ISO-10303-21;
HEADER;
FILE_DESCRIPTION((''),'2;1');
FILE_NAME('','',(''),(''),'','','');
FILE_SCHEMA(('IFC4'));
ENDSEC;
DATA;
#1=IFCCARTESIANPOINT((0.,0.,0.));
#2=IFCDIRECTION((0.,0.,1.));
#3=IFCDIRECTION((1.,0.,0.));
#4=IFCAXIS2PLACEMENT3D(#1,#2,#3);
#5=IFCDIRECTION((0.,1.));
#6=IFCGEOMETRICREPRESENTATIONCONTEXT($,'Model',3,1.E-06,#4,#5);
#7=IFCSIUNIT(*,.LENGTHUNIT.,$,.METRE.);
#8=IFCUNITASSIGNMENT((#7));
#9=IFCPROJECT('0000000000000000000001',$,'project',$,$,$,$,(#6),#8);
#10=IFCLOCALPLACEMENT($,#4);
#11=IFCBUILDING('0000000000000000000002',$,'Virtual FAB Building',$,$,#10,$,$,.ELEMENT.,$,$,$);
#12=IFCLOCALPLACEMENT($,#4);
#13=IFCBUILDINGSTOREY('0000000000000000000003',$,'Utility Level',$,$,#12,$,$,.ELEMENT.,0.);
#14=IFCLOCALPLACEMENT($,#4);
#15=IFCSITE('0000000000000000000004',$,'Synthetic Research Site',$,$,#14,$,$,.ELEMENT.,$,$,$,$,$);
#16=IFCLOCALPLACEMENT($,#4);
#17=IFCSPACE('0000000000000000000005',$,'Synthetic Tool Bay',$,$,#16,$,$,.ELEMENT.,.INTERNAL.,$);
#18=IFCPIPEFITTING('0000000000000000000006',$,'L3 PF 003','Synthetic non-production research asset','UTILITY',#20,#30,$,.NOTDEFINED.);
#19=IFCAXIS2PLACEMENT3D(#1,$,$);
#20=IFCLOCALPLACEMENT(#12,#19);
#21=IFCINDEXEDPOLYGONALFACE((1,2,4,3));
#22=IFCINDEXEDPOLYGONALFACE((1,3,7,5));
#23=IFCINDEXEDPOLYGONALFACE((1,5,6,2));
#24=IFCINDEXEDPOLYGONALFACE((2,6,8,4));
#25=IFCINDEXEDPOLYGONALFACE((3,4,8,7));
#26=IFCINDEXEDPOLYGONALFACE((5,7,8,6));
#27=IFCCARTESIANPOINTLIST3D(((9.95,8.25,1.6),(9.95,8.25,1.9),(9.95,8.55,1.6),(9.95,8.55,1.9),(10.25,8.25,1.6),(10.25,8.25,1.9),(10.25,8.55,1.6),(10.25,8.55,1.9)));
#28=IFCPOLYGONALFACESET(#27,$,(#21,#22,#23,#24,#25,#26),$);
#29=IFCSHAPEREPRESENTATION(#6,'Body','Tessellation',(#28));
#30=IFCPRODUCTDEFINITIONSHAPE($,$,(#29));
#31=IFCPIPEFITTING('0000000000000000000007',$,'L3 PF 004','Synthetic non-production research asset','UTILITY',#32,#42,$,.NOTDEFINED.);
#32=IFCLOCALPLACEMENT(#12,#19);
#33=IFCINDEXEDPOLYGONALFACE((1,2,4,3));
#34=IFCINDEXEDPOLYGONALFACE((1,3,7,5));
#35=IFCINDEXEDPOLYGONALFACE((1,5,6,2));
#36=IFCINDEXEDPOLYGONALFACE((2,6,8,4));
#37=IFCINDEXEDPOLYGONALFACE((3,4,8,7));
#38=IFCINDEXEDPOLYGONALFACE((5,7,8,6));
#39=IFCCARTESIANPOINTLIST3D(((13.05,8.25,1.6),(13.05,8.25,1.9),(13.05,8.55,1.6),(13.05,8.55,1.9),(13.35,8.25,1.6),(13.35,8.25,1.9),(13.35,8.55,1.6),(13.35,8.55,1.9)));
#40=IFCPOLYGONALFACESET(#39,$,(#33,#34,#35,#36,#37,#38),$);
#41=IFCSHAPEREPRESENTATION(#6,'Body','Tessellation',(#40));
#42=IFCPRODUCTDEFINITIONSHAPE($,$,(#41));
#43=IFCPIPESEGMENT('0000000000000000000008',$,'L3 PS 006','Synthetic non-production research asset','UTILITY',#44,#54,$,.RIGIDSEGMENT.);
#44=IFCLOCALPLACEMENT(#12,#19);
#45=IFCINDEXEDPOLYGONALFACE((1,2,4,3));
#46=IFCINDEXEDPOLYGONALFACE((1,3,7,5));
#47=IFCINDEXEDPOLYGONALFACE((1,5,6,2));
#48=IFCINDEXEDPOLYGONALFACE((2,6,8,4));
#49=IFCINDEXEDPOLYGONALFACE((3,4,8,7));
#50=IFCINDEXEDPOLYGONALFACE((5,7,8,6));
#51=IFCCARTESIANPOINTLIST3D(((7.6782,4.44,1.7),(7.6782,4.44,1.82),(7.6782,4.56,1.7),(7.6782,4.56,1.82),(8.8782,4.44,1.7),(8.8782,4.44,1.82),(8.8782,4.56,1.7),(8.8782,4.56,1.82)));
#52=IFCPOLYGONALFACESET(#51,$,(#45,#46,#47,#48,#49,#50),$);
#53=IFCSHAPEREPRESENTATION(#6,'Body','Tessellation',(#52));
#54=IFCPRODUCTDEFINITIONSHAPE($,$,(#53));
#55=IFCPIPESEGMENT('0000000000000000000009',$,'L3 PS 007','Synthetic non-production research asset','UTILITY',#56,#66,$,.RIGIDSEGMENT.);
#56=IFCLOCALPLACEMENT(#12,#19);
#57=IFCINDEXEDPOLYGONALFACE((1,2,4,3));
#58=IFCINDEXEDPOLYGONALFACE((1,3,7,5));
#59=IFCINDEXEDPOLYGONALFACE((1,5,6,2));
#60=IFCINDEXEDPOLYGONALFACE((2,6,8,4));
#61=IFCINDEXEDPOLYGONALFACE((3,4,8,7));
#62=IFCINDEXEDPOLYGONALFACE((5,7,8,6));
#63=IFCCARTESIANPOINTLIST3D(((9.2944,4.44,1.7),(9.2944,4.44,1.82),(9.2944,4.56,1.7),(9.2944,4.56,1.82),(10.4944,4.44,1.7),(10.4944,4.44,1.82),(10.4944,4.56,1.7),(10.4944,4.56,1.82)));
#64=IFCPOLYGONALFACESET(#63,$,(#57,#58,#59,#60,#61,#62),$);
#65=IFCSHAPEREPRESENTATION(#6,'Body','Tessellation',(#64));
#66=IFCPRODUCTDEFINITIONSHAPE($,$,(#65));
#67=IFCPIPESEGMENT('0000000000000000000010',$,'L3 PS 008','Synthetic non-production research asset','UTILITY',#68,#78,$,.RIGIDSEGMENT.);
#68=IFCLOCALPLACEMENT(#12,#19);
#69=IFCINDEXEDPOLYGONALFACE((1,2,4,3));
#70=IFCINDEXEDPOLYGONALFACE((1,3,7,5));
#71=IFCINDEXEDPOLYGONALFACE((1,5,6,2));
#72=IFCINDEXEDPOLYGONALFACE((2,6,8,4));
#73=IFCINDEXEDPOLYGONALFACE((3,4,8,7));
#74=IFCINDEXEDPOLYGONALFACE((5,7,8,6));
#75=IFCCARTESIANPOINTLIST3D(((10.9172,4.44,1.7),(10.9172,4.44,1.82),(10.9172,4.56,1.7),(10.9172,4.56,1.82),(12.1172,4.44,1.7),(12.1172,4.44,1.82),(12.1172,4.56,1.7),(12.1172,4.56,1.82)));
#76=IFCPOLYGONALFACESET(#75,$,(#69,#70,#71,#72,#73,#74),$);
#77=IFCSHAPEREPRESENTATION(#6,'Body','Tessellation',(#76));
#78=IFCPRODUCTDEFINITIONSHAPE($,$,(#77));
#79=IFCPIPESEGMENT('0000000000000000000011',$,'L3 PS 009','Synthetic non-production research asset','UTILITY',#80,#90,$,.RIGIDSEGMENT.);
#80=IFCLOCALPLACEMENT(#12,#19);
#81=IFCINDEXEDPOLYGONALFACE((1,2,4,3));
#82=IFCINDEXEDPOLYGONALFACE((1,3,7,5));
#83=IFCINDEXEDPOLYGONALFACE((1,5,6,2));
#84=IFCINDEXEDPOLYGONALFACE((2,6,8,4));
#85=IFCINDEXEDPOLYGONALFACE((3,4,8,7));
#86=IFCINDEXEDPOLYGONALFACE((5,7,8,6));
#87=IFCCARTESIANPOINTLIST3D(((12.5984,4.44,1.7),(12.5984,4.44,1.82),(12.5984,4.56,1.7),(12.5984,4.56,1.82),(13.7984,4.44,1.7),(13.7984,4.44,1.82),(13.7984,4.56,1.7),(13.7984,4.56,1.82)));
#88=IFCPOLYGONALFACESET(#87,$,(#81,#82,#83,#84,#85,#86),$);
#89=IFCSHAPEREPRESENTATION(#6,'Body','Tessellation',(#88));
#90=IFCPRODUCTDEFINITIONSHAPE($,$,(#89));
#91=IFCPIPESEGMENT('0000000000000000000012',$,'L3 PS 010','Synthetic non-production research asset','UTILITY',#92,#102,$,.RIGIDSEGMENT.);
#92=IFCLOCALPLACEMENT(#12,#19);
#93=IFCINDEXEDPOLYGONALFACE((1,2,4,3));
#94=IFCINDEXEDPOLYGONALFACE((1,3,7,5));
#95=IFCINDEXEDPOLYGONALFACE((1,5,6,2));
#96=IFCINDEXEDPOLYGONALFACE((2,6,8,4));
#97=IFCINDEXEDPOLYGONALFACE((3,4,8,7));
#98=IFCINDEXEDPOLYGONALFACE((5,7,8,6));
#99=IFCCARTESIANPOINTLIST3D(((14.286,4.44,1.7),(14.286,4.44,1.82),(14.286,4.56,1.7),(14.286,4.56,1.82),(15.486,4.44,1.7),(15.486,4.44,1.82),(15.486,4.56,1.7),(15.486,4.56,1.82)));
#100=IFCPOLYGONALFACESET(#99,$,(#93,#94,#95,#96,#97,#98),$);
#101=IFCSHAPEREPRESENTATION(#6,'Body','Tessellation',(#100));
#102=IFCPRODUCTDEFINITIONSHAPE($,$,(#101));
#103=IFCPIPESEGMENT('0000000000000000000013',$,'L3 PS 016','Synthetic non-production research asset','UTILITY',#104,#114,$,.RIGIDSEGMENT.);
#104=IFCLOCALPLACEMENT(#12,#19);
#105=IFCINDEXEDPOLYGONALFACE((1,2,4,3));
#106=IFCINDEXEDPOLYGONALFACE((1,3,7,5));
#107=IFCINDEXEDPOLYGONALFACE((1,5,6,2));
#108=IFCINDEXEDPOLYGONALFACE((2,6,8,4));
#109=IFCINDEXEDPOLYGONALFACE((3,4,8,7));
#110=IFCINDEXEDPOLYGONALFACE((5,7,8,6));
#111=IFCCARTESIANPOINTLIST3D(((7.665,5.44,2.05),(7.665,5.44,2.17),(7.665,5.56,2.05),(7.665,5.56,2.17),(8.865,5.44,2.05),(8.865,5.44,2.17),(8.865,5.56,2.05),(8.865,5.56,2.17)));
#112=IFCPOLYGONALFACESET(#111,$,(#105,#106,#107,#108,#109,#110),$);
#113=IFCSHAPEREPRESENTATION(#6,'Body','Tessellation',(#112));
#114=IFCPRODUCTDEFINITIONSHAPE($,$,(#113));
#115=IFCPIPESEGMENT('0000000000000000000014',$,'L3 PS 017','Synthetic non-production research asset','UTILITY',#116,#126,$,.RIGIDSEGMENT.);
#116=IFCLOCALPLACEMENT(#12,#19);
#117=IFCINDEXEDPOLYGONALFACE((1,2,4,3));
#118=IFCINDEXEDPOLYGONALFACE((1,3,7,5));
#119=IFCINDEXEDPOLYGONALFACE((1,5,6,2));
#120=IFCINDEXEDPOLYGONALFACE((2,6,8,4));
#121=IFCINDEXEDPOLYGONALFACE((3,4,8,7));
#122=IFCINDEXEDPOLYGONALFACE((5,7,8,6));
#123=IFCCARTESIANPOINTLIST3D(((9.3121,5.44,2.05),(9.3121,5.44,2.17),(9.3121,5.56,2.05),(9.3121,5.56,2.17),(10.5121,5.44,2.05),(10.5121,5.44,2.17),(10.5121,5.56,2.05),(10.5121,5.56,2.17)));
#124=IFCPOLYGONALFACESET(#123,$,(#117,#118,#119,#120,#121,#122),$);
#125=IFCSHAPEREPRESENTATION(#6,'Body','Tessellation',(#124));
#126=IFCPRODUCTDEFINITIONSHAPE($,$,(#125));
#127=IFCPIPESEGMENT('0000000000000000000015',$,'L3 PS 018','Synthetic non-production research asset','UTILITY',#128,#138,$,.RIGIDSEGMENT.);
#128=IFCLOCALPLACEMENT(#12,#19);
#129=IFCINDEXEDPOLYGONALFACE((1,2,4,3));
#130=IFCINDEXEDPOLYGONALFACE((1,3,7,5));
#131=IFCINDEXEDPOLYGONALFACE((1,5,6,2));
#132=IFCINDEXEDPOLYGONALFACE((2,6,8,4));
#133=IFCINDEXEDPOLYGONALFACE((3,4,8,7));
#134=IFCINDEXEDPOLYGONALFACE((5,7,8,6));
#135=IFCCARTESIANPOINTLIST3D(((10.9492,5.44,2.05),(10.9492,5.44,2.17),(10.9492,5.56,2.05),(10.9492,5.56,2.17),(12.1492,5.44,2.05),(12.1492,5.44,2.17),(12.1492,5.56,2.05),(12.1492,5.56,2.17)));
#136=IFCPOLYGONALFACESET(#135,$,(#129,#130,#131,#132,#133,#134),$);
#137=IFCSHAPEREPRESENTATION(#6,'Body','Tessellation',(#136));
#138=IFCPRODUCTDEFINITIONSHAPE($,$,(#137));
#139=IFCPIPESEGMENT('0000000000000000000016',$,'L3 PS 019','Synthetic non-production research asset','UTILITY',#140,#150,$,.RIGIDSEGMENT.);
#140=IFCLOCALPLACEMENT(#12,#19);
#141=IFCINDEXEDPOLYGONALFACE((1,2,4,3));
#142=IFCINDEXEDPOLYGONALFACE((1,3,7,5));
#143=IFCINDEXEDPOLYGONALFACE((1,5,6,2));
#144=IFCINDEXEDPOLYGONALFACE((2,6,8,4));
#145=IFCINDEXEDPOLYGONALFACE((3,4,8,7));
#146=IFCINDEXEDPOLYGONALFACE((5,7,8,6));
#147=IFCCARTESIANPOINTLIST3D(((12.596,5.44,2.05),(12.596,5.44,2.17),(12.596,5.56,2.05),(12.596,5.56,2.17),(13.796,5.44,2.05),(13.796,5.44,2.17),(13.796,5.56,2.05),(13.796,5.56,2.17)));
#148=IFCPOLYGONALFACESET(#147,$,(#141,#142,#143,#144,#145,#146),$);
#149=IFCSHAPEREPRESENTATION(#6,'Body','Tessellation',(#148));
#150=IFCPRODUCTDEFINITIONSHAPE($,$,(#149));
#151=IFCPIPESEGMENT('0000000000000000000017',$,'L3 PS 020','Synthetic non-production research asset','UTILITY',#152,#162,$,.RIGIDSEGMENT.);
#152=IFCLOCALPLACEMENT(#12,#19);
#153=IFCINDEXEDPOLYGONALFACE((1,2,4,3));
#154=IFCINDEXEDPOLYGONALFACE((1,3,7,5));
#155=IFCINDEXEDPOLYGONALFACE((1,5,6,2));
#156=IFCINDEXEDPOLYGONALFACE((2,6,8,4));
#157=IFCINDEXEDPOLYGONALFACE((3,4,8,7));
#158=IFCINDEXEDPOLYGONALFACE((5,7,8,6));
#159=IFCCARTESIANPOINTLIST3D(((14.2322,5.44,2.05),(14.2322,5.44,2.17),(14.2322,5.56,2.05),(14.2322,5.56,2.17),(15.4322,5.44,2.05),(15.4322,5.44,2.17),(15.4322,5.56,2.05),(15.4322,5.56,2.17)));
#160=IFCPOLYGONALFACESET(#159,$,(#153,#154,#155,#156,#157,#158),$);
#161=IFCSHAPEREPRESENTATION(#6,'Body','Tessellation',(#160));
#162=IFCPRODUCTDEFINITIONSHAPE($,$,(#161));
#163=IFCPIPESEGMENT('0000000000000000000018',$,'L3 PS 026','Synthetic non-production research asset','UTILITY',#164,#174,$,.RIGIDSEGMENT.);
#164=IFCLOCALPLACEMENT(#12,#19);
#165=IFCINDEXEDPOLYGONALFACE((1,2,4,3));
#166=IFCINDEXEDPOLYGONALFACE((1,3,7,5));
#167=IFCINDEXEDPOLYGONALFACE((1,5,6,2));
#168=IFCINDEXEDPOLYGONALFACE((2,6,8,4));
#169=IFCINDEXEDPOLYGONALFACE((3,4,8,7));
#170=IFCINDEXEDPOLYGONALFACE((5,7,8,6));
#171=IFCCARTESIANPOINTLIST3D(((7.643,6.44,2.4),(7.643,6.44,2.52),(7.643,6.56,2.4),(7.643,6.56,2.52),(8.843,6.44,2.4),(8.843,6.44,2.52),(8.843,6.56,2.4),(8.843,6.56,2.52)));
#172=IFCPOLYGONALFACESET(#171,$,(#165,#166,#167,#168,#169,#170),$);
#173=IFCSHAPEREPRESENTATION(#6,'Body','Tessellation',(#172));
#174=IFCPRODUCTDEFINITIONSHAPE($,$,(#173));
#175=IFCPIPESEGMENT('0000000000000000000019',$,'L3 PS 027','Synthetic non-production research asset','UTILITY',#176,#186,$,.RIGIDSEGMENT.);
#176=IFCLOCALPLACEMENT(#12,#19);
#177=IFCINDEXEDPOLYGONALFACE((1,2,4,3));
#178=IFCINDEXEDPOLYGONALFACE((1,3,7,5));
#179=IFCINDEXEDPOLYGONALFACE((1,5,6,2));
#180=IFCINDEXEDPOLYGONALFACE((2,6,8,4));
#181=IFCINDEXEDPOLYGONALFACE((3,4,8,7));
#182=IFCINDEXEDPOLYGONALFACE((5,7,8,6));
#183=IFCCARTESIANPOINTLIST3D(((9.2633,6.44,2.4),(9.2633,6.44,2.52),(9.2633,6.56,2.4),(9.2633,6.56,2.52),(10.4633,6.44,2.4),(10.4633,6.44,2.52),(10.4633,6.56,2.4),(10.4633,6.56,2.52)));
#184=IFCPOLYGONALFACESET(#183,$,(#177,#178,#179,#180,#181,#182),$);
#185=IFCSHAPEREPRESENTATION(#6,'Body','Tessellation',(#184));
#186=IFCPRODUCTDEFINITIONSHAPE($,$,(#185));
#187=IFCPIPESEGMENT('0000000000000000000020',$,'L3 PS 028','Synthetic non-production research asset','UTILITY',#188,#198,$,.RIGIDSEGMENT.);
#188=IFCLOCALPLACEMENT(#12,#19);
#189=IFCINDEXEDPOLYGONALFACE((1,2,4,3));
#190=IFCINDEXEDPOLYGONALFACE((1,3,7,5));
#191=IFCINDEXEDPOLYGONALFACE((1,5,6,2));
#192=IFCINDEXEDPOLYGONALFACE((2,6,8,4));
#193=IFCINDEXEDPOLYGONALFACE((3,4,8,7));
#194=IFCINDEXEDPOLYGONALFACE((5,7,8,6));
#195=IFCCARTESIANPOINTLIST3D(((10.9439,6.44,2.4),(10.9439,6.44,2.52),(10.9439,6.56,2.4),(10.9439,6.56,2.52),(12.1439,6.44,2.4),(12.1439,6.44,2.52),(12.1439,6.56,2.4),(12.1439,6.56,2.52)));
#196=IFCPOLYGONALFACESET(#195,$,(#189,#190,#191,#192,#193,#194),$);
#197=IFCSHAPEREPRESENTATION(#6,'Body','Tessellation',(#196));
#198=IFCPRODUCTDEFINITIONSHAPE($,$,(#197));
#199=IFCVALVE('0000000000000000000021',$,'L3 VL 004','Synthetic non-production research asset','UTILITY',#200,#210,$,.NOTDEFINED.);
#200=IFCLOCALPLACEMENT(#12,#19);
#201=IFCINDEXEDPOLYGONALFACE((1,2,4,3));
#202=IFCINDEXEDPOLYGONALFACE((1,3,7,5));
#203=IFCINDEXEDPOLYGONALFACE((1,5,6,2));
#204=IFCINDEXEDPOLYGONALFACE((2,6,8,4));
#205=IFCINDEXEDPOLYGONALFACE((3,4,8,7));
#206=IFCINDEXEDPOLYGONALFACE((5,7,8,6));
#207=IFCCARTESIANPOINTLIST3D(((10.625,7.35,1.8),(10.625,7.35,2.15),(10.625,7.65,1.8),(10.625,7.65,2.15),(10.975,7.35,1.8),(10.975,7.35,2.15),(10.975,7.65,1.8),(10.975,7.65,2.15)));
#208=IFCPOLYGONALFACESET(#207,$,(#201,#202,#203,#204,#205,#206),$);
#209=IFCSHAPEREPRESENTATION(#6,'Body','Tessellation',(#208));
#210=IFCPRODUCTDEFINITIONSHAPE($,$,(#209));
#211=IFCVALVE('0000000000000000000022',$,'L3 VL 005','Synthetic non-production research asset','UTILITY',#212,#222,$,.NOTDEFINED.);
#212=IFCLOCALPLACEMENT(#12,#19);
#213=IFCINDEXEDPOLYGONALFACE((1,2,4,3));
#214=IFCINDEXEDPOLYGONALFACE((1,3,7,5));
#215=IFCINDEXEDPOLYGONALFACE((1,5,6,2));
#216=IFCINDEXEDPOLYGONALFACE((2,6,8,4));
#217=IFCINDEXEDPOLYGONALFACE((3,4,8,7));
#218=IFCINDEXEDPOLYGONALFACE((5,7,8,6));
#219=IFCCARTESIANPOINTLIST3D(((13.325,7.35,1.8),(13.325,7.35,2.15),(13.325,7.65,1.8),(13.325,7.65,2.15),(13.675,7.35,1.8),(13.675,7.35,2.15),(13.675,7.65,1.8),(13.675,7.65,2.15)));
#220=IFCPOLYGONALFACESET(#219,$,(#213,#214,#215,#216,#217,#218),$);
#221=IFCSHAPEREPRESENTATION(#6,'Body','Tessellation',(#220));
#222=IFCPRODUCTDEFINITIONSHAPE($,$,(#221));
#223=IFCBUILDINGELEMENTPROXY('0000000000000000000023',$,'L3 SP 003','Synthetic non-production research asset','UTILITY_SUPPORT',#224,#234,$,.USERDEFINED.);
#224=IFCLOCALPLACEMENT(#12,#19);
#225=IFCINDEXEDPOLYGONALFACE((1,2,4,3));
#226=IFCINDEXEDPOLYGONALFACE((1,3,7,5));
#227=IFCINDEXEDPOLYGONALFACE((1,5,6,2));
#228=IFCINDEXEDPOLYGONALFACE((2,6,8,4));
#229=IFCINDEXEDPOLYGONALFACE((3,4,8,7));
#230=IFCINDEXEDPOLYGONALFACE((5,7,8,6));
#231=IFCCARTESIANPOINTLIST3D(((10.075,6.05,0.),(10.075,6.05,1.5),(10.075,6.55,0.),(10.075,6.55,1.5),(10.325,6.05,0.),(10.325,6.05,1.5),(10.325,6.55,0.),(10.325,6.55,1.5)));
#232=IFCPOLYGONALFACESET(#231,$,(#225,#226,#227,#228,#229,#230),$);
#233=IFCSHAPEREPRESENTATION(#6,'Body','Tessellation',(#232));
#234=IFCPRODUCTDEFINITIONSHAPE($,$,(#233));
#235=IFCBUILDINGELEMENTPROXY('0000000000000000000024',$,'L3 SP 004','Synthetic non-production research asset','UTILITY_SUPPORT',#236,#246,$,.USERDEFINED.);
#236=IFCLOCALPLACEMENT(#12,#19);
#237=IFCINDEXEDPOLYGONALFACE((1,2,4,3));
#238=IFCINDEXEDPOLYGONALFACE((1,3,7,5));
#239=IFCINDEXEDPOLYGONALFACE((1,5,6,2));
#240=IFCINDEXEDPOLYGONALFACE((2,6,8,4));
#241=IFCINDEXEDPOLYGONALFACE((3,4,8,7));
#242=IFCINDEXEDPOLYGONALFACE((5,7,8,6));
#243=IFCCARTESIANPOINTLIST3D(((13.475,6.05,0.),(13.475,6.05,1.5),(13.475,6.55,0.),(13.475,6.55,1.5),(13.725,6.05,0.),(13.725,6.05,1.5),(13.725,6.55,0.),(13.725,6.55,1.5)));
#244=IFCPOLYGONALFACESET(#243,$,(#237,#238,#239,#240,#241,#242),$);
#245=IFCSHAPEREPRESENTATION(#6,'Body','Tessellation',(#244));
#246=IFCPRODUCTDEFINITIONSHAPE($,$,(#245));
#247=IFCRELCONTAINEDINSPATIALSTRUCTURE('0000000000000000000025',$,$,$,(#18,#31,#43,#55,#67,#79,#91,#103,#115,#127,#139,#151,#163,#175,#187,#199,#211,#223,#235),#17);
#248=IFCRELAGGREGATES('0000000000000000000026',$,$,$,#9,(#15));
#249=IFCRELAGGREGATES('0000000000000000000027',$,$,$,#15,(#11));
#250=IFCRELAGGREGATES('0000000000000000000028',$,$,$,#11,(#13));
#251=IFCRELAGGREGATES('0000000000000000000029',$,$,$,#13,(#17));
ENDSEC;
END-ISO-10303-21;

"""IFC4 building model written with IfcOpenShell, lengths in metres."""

from ifc_helpers import new_model, si_unit, direction, frame, origin_with_axes, origin_2d_with_axis, place, context, project, spatial, rectangle, extrude, element, save


model = new_model("IFC4")

# Units and contexts
model_context = context("Model", 3, precision=1e-06, world=origin_with_axes(), true_north=direction((0.0, 1.0)))
ifc_project = project(units=[si_unit("LENGTHUNIT", "METRE")], contexts=[model_context])

# Site, building, storey, space
site_placement = place(None, origin_with_axes())
site = spatial("IfcSite", under=ifc_project, at=site_placement, Name="Synthetic Research Site", CompositionType="ELEMENT")
building_placement = place(None, origin_with_axes())
building = spatial("IfcBuilding", under=site, at=building_placement, Name="Virtual FAB Building", CompositionType="ELEMENT")
storey_placement = place(None, origin_with_axes())
storey = spatial("IfcBuildingStorey", under=building, at=storey_placement, Name="Utility Level", CompositionType="ELEMENT", Elevation=0.0)
space_placement = place(None, origin_with_axes())
space = spatial("IfcSpace", under=storey, at=space_placement, Name="Synthetic Tool Bay", CompositionType="ELEMENT", PredefinedType="INTERNAL")

# Pipe fittings
for number, where, z_axis, x_axis, name in (
    (1, (10.1, 8.4, 1.6), (0.0, 0.0, 1.0), (1.0, 0.0, 0.0), "L3 PF 003"),
    (2, (13.2, 8.4, 1.6), (0.0, 0.0, 1.0), (1.0, 0.0, 0.0), "L3 PF 004"),
):
    element("IfcPipeFitting", number, at=place(None, frame(where, z_axis=z_axis, x_axis=x_axis)), inside=space, Name=name, Description="Synthetic non-production research asset", ObjectType="UTILITY", PredefinedType="NOTDEFINED", context=model_context, shape_type="SweptSolid", body=[
        extrude(rectangle(XDim=0.3, YDim=0.3, at=origin_2d_with_axis()), origin_with_axes(), (0.0, 0.0, 1.0), 0.3),
    ])

# Pipe segments
for number, where, z_axis, x_axis, name in (
    (3, (8.2782, 4.5, 1.7), (0.0, 0.0, 1.0), (1.0, 0.0, 0.0), "L3 PS 006"),
    (4, (9.8944, 4.5, 1.7), (0.0, 0.0, 1.0), (1.0, 0.0, 0.0), "L3 PS 007"),
    (5, (11.5172, 4.5, 1.7), (0.0, 0.0, 1.0), (1.0, 0.0, 0.0), "L3 PS 008"),
    (6, (13.1984, 4.5, 1.7), (0.0, 0.0, 1.0), (1.0, 0.0, 0.0), "L3 PS 009"),
    (7, (14.886, 4.5, 1.7), (0.0, 0.0, 1.0), (1.0, 0.0, 0.0), "L3 PS 010"),
    (8, (8.265, 5.5, 2.05), (0.0, 0.0, 1.0), (1.0, 0.0, 0.0), "L3 PS 016"),
    (9, (9.9121, 5.5, 2.05), (0.0, 0.0, 1.0), (1.0, 0.0, 0.0), "L3 PS 017"),
    (10, (11.5492, 5.5, 2.05), (0.0, 0.0, 1.0), (1.0, 0.0, 0.0), "L3 PS 018"),
    (11, (13.196, 5.5, 2.05), (0.0, 0.0, 1.0), (1.0, 0.0, 0.0), "L3 PS 019"),
    (12, (14.8322, 5.5, 2.05), (0.0, 0.0, 1.0), (1.0, 0.0, 0.0), "L3 PS 020"),
    (13, (8.243, 6.5, 2.4), (0.0, 0.0, 1.0), (1.0, 0.0, 0.0), "L3 PS 026"),
    (14, (9.8633, 6.5, 2.4), (0.0, 0.0, 1.0), (1.0, 0.0, 0.0), "L3 PS 027"),
    (15, (11.5439, 6.5, 2.4), (0.0, 0.0, 1.0), (1.0, 0.0, 0.0), "L3 PS 028"),
):
    element("IfcPipeSegment", number, at=place(None, frame(where, z_axis=z_axis, x_axis=x_axis)), inside=space, Name=name, Description="Synthetic non-production research asset", ObjectType="UTILITY", PredefinedType="RIGIDSEGMENT", context=model_context, shape_type="SweptSolid", body=[
        extrude(rectangle(XDim=1.2, YDim=0.12, at=origin_2d_with_axis()), origin_with_axes(), (0.0, 0.0, 1.0), 0.12),
    ])

# Valves
for number, where, z_axis, x_axis, name in (
    (16, (10.8, 7.5, 1.8), (0.0, 0.0, 1.0), (1.0, 0.0, 0.0), "L3 VL 004"),
    (17, (13.5, 7.5, 1.8), (0.0, 0.0, 1.0), (1.0, 0.0, 0.0), "L3 VL 005"),
):
    element("IfcValve", number, at=place(None, frame(where, z_axis=z_axis, x_axis=x_axis)), inside=space, Name=name, Description="Synthetic non-production research asset", ObjectType="UTILITY", PredefinedType="NOTDEFINED", context=model_context, shape_type="SweptSolid", body=[
        extrude(rectangle(XDim=0.35, YDim=0.3, at=origin_2d_with_axis()), origin_with_axes(), (0.0, 0.0, 1.0), 0.35),
    ])

# Building element proxies
for number, where, z_axis, x_axis, name in (
    (18, (10.2, 6.3, 0.0), (0.0, 0.0, 1.0), (1.0, 0.0, 0.0), "L3 SP 003"),
    (19, (13.6, 6.3, 0.0), (0.0, 0.0, 1.0), (1.0, 0.0, 0.0), "L3 SP 004"),
):
    element("IfcBuildingElementProxy", number, at=place(None, frame(where, z_axis=z_axis, x_axis=x_axis)), inside=space, Name=name, Description="Synthetic non-production research asset", ObjectType="UTILITY_SUPPORT", PredefinedType="USERDEFINED", context=model_context, shape_type="SweptSolid", body=[
        extrude(rectangle(XDim=0.25, YDim=0.5, at=origin_2d_with_axis()), origin_with_axes(), (0.0, 0.0, 1.0), 1.5),
    ])

save(model, "model.ifc")
